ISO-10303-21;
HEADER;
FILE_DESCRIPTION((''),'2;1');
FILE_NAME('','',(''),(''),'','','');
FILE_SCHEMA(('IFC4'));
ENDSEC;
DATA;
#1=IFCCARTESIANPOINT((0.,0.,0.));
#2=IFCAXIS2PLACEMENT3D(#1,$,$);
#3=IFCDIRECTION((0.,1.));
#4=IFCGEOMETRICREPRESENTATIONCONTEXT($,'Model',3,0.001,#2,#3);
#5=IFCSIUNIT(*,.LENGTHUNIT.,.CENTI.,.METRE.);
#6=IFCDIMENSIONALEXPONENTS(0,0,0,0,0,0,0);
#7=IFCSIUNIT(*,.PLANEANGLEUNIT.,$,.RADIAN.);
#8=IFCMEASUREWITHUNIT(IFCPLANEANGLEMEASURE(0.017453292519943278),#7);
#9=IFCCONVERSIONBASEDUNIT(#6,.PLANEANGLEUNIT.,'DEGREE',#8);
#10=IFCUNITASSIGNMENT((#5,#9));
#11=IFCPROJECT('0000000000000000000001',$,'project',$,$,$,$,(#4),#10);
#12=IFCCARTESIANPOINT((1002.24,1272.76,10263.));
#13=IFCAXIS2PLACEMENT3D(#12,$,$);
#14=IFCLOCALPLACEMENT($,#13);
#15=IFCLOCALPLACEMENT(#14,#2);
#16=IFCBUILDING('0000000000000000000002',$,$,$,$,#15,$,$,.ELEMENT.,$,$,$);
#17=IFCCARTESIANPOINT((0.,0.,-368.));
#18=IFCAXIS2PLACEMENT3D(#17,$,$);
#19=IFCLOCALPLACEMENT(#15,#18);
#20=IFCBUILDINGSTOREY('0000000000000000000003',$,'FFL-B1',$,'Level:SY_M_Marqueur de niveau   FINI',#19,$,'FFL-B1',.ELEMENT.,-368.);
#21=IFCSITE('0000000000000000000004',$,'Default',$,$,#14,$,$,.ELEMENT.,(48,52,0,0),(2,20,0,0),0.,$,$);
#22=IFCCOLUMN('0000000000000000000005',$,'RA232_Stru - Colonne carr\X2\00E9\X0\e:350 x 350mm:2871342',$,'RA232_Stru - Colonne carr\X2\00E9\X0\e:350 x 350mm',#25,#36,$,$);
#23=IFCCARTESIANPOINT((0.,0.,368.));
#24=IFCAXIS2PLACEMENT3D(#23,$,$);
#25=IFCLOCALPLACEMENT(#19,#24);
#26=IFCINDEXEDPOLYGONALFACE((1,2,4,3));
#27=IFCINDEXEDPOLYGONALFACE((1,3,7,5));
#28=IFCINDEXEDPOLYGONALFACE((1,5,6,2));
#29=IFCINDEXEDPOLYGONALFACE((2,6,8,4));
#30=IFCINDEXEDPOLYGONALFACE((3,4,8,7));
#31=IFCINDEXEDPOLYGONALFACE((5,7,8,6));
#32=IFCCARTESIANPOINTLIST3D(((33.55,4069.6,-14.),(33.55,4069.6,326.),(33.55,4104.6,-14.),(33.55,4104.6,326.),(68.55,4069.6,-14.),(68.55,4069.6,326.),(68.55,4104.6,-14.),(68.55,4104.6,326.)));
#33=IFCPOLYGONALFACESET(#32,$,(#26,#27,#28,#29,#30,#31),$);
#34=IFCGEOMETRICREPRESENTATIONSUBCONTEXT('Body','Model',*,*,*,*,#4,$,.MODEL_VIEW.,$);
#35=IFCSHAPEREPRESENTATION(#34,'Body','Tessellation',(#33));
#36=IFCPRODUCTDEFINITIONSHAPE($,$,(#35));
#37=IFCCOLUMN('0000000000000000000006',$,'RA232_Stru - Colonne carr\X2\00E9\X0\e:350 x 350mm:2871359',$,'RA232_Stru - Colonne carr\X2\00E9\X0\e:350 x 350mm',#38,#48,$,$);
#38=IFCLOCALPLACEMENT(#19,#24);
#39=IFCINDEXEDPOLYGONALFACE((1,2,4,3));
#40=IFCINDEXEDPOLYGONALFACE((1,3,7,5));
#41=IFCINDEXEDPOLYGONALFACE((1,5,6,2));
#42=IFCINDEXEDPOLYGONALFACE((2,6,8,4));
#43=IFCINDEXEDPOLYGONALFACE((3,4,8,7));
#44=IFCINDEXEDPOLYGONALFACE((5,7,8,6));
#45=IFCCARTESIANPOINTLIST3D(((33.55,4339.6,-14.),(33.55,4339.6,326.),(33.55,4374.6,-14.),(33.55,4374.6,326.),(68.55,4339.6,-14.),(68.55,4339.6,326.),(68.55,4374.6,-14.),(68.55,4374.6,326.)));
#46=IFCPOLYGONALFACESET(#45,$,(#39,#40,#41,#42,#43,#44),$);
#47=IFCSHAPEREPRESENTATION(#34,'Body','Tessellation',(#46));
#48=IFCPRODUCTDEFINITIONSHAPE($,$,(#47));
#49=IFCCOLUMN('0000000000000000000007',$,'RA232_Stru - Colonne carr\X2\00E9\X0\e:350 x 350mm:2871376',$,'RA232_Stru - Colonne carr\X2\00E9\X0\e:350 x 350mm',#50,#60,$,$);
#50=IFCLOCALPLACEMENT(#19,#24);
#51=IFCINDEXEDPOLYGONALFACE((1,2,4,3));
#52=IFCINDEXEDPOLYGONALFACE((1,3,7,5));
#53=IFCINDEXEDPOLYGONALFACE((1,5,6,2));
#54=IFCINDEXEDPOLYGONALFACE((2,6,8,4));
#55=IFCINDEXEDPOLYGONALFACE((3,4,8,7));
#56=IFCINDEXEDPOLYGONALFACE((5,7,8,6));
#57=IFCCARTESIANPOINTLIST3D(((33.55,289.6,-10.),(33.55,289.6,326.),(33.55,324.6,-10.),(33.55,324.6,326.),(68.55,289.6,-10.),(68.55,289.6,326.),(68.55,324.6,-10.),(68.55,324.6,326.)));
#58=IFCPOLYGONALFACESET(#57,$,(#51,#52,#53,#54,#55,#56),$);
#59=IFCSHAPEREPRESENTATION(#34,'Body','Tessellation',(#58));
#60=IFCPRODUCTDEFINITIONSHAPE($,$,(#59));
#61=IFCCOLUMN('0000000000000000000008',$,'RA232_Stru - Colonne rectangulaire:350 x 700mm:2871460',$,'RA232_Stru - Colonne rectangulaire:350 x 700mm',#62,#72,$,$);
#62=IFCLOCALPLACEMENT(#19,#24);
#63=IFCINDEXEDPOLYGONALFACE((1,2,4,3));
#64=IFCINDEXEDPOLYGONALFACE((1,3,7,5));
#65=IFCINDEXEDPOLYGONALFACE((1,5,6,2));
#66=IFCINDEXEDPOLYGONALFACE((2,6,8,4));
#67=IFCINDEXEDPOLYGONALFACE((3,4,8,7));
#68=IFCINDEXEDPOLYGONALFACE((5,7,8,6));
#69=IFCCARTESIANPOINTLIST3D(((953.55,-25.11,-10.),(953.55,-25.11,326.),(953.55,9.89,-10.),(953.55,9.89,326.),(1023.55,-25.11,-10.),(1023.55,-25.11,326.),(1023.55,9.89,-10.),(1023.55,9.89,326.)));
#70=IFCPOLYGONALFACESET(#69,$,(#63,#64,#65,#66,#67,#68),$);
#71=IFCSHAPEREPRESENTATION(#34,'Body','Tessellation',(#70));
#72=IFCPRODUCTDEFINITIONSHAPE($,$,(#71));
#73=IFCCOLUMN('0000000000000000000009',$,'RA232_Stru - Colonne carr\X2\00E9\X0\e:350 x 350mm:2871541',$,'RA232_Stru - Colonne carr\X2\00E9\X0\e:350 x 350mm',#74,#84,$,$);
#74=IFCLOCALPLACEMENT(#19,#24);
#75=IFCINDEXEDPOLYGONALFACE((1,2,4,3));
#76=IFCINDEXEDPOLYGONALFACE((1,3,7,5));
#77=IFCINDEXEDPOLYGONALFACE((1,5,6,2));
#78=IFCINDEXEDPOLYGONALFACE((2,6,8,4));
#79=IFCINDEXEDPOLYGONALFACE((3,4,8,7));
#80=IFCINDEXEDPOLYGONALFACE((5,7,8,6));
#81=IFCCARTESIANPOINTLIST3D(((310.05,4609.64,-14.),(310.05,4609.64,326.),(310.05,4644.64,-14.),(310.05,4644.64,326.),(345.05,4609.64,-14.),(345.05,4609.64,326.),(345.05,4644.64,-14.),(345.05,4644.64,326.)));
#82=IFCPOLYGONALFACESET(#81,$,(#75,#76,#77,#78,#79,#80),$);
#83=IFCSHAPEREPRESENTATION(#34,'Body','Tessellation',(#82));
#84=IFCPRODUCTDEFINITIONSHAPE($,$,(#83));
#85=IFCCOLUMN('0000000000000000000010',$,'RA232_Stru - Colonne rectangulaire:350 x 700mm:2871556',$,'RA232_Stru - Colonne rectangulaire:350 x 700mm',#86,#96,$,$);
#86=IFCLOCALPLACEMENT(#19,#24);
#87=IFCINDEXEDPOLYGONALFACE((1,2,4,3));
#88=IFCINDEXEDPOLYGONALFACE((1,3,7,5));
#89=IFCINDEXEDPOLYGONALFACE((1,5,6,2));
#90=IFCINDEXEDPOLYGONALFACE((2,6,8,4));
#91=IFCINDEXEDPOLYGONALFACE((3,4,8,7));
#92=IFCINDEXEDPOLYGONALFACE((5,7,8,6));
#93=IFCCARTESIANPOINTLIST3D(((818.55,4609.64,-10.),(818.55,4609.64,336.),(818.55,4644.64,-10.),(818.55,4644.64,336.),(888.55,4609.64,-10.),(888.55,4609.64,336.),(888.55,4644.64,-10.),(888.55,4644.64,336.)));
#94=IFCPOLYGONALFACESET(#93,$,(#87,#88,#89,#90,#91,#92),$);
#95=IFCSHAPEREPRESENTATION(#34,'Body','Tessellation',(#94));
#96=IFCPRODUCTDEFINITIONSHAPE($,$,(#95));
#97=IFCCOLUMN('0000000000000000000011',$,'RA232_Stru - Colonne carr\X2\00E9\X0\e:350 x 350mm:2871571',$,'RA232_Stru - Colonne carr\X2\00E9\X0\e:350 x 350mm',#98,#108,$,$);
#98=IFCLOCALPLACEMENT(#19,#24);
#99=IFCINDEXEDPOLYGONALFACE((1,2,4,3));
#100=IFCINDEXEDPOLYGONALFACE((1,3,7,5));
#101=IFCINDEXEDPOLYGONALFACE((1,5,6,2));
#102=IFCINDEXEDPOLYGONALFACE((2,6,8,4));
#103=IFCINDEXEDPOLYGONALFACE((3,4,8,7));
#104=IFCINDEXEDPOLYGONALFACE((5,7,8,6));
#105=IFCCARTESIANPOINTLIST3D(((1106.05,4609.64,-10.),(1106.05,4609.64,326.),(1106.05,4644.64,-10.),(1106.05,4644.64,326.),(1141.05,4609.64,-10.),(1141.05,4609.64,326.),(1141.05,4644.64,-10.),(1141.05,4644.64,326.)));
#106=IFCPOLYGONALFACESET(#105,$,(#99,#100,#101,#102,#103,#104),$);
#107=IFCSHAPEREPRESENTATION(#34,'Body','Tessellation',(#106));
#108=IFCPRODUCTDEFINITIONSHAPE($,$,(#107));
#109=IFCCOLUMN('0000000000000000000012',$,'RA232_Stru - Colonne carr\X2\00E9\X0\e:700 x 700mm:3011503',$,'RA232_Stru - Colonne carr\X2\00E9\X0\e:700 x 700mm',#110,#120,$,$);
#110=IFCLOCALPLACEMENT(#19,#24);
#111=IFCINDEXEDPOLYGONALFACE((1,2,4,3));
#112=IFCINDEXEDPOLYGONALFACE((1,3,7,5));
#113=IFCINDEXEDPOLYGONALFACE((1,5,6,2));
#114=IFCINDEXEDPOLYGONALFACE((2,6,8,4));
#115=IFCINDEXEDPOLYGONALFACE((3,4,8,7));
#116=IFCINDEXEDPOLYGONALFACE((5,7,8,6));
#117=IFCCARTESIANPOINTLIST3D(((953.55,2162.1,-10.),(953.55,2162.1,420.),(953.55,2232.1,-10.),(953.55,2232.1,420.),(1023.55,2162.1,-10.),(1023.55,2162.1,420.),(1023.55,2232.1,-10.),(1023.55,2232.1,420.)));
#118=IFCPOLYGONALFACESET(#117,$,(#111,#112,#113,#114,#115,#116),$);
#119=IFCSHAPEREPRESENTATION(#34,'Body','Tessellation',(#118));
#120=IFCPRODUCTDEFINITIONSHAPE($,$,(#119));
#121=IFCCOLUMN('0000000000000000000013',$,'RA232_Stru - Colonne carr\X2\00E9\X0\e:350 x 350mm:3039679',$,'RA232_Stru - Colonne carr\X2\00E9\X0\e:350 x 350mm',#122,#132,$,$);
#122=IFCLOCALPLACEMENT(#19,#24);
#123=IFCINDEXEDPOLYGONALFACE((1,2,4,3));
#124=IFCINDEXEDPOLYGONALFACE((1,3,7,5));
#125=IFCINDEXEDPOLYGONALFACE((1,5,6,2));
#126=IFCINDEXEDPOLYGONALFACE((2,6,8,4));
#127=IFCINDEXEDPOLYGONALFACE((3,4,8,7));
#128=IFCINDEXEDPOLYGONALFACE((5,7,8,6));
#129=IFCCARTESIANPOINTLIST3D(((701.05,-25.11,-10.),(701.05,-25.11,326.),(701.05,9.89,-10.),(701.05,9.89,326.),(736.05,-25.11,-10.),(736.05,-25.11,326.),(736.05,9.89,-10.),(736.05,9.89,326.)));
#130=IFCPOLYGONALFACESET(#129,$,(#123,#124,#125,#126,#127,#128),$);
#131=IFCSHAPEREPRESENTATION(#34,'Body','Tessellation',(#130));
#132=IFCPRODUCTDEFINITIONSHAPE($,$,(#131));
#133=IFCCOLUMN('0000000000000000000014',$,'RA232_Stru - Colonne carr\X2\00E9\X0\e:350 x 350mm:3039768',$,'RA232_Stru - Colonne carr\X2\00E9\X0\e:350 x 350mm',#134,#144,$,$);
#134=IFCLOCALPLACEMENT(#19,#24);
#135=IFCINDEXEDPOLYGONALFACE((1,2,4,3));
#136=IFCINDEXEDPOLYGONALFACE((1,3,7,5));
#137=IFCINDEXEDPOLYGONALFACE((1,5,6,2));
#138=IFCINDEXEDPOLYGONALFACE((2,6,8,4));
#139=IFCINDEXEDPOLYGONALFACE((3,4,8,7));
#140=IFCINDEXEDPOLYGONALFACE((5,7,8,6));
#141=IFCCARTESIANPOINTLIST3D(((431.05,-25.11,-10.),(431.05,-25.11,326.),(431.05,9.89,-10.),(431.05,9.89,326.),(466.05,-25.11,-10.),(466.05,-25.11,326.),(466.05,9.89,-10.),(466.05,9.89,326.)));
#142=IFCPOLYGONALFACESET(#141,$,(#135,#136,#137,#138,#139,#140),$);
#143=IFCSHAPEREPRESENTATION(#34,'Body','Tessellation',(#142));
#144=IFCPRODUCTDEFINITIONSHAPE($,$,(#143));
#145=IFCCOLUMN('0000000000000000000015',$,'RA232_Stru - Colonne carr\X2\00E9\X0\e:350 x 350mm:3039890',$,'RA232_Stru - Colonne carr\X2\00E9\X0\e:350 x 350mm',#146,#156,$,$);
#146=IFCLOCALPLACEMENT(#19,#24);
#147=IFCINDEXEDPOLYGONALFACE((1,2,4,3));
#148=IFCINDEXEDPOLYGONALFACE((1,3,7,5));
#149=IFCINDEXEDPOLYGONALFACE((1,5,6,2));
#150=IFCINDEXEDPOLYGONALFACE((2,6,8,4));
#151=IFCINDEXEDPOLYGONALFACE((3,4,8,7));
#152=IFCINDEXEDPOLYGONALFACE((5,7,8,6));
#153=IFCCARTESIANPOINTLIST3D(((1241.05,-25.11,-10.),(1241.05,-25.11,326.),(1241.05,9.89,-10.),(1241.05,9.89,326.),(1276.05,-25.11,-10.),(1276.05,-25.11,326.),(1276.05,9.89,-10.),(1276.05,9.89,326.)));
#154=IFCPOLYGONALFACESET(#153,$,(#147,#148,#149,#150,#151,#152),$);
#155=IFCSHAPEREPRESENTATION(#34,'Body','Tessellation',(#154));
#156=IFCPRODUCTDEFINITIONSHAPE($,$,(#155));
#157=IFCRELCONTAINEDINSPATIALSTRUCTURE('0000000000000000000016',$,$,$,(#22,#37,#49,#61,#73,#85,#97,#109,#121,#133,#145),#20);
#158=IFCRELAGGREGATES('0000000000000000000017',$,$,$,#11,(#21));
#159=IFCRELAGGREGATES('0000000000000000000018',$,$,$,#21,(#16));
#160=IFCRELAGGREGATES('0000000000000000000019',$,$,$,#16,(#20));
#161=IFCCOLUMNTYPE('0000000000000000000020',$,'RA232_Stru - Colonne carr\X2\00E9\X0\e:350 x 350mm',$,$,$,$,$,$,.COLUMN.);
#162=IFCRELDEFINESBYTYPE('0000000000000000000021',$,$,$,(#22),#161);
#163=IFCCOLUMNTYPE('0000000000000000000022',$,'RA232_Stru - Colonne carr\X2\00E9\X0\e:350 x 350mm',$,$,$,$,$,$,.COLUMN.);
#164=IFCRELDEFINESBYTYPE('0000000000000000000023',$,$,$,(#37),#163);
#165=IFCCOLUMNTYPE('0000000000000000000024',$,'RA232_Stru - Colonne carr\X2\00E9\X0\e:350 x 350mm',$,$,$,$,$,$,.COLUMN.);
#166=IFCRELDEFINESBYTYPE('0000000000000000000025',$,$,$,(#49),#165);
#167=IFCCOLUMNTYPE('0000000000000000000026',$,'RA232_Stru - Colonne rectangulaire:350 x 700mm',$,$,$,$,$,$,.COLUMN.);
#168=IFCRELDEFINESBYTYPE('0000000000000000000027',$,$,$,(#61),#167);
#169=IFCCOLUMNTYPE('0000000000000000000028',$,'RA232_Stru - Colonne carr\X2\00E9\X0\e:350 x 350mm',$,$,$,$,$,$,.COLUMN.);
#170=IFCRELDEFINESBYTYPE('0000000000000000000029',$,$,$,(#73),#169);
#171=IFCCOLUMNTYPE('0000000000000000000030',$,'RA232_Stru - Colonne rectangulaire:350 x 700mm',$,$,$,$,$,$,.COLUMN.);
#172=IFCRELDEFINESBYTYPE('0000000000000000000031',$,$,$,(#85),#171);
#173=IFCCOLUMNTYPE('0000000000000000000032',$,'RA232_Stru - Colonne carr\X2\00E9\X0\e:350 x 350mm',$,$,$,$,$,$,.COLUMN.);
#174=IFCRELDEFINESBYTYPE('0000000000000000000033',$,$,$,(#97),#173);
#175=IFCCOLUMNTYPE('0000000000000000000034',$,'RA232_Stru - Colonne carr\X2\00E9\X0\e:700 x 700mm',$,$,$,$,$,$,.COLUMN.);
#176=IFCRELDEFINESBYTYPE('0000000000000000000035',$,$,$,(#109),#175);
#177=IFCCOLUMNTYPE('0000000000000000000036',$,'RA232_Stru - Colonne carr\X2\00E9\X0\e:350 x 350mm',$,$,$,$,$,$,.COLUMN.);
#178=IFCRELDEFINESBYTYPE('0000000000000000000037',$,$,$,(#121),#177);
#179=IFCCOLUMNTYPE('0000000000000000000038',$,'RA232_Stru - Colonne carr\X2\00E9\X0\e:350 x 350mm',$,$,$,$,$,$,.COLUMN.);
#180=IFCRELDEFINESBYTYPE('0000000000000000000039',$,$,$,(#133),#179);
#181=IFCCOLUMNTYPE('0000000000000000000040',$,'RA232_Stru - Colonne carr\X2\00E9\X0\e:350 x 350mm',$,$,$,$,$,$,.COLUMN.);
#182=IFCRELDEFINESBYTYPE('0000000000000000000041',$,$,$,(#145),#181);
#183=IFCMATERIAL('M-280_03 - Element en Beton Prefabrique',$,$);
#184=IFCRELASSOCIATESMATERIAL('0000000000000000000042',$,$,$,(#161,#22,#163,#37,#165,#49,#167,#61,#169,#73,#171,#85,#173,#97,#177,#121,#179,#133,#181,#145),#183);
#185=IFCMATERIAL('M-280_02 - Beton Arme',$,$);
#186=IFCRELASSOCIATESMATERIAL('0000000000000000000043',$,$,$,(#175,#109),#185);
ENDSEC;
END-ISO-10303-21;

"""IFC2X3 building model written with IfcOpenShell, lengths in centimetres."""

from ifc_helpers import new_model, entity, si_unit, converted_unit, direction, frame, frame_2d, origin, place, context, subcontext, project, spatial, rectangle, extrude, source, transform, mapped, material, type_object, type_shapes, element, save


model = new_model("IFC2X3")

# Units and contexts
model_context = context("Model", 3, precision=0.001, world=origin(), true_north=direction((0.0, 1.0)))
body_context = subcontext(model_context, "Body", "Model", "MODEL_VIEW")
ifc_project = project(units=[si_unit("LENGTHUNIT", "METRE", prefix="CENTI"), converted_unit("PLANEANGLEUNIT", "DEGREE", entity("IfcPlaneAngleMeasure", 0.017453292519943278), si_unit("PLANEANGLEUNIT", "RADIAN"), dimensions=[0, 0, 0, 0, 0, 0, 0])], contexts=[model_context])

# Site, building, storey
site_placement = place(None, frame((1002.24, 1272.76, 10263.0)))
site = spatial("IfcSite", under=ifc_project, at=site_placement, Name="Default", CompositionType="ELEMENT", RefLatitude=(48, 52, 0, 0), RefLongitude=(2, 20, 0, 0), RefElevation=0.0)
building_placement = place(site_placement, origin())
building = spatial("IfcBuilding", under=site, at=building_placement, CompositionType="ELEMENT")
storey_placement = place(building_placement, frame((0.0, 0.0, -368.0)))
storey = spatial("IfcBuildingStorey", under=building, at=storey_placement, Name="FFL-B1", ObjectType="Level:SY_M_Marqueur de niveau   FINI", LongName="FFL-B1", CompositionType="ELEMENT", Elevation=-368.0)

# Columns
ifc_material_1 = material(Name="M-280_03 - Element en Beton Prefabrique")
column_type_1 = type_object("IfcColumnType", Name="RA232_Stru - Colonne carrée:350 x 350mm", PredefinedType="COLUMN", material=ifc_material_1)
shared_shape_1 = source(origin(), body_context, "Body", "SweptSolid", [
    extrude(rectangle(XDim=35.0, YDim=35.0, at=frame_2d((0.0, 0.0), x_axis=(1.0, 0.0))), frame((51.05, 4087.1, -14.0), z_axis=(0.0, 0.0, 1.0), x_axis=(-1.0, 0.0, 0.0)), (0.0, 0.0, 1.0), 340.0),
])
type_shapes(column_type_1, [shared_shape_1])
column_1_placement = place(storey_placement, frame((0.0, 0.0, 368.0)))
element("IfcColumn", 1, at=column_1_placement, inside=storey, type_object=column_type_1, material=ifc_material_1, Name="RA232_Stru - Colonne carrée:350 x 350mm:2871342", ObjectType="RA232_Stru - Colonne carrée:350 x 350mm", context=body_context, shape_type="MappedRepresentation", body=[
    mapped(shared_shape_1, transform((0.0, 0.0, 0.0), scale=1.0)),
])
column_type_2 = type_object("IfcColumnType", Name="RA232_Stru - Colonne carrée:350 x 350mm", PredefinedType="COLUMN", material=ifc_material_1)
shared_shape_2 = source(origin(), body_context, "Body", "SweptSolid", [
    extrude(rectangle(XDim=35.0, YDim=35.0, at=frame_2d((0.0, 0.0), x_axis=(1.0, 0.0))), frame((51.05, 4357.1, -14.0), z_axis=(0.0, 0.0, 1.0), x_axis=(-1.0, 0.0, 0.0)), (0.0, 0.0, 1.0), 340.0),
])
type_shapes(column_type_2, [shared_shape_2])
column_2_placement = place(storey_placement, frame((0.0, 0.0, 368.0)))
element("IfcColumn", 2, at=column_2_placement, inside=storey, type_object=column_type_2, material=ifc_material_1, Name="RA232_Stru - Colonne carrée:350 x 350mm:2871359", ObjectType="RA232_Stru - Colonne carrée:350 x 350mm", context=body_context, shape_type="MappedRepresentation", body=[
    mapped(shared_shape_2, transform((0.0, 0.0, 0.0), scale=1.0)),
])
column_type_3 = type_object("IfcColumnType", Name="RA232_Stru - Colonne carrée:350 x 350mm", PredefinedType="COLUMN", material=ifc_material_1)
shared_shape_3 = source(origin(), body_context, "Body", "SweptSolid", [
    extrude(rectangle(XDim=35.0, YDim=35.0, at=frame_2d((0.0, 0.0), x_axis=(1.0, 0.0))), frame((51.05, 307.1, -10.0), z_axis=(0.0, 0.0, 1.0), x_axis=(-1.0, 0.0, 0.0)), (0.0, 0.0, 1.0), 336.0),
])
type_shapes(column_type_3, [shared_shape_3])
column_3_placement = place(storey_placement, frame((0.0, 0.0, 368.0)))
element("IfcColumn", 3, at=column_3_placement, inside=storey, type_object=column_type_3, material=ifc_material_1, Name="RA232_Stru - Colonne carrée:350 x 350mm:2871376", ObjectType="RA232_Stru - Colonne carrée:350 x 350mm", context=body_context, shape_type="MappedRepresentation", body=[
    mapped(shared_shape_3, transform((0.0, 0.0, 0.0), scale=1.0)),
])
column_type_4 = type_object("IfcColumnType", Name="RA232_Stru - Colonne rectangulaire:350 x 700mm", PredefinedType="COLUMN", material=ifc_material_1)
shared_shape_4 = source(origin(), body_context, "Body", "SweptSolid", [
    extrude(rectangle(XDim=35.0, YDim=70.0, at=frame_2d((0.0, 0.0), x_axis=(1.0, 0.0))), frame((988.55, -7.61, -10.0), z_axis=(0.0, 0.0, 1.0), x_axis=(0.0, -1.0, 0.0)), (0.0, 0.0, 1.0), 336.0),
])
type_shapes(column_type_4, [shared_shape_4])
column_4_placement = place(storey_placement, frame((0.0, 0.0, 368.0)))
element("IfcColumn", 4, at=column_4_placement, inside=storey, type_object=column_type_4, material=ifc_material_1, Name="RA232_Stru - Colonne rectangulaire:350 x 700mm:2871460", ObjectType="RA232_Stru - Colonne rectangulaire:350 x 700mm", context=body_context, shape_type="MappedRepresentation", body=[
    mapped(shared_shape_4, transform((0.0, 0.0, 0.0), scale=1.0)),
])
column_type_5 = type_object("IfcColumnType", Name="RA232_Stru - Colonne carrée:350 x 350mm", PredefinedType="COLUMN", material=ifc_material_1)
shared_shape_5 = source(origin(), body_context, "Body", "SweptSolid", [
    extrude(rectangle(XDim=35.0, YDim=35.0, at=frame_2d((0.0, 0.0), x_axis=(1.0, 0.0))), frame((327.55, 4627.14, -14.0), z_axis=(0.0, 0.0, 1.0), x_axis=(-1.0, 0.0, 0.0)), (0.0, 0.0, 1.0), 340.0),
])
type_shapes(column_type_5, [shared_shape_5])
column_5_placement = place(storey_placement, frame((0.0, 0.0, 368.0)))
element("IfcColumn", 5, at=column_5_placement, inside=storey, type_object=column_type_5, material=ifc_material_1, Name="RA232_Stru - Colonne carrée:350 x 350mm:2871541", ObjectType="RA232_Stru - Colonne carrée:350 x 350mm", context=body_context, shape_type="MappedRepresentation", body=[
    mapped(shared_shape_5, transform((0.0, 0.0, 0.0), scale=1.0)),
])
column_type_6 = type_object("IfcColumnType", Name="RA232_Stru - Colonne rectangulaire:350 x 700mm", PredefinedType="COLUMN", material=ifc_material_1)
shared_shape_6 = source(origin(), body_context, "Body", "SweptSolid", [
    extrude(rectangle(XDim=35.0, YDim=70.0, at=frame_2d((0.0, 0.0), x_axis=(1.0, 0.0))), frame((853.55, 4627.14, -10.0), z_axis=(0.0, 0.0, 1.0), x_axis=(0.0, -1.0, 0.0)), (0.0, 0.0, 1.0), 346.0),
])
type_shapes(column_type_6, [shared_shape_6])
column_6_placement = place(storey_placement, frame((0.0, 0.0, 368.0)))
element("IfcColumn", 6, at=column_6_placement, inside=storey, type_object=column_type_6, material=ifc_material_1, Name="RA232_Stru - Colonne rectangulaire:350 x 700mm:2871556", ObjectType="RA232_Stru - Colonne rectangulaire:350 x 700mm", context=body_context, shape_type="MappedRepresentation", body=[
    mapped(shared_shape_6, transform((0.0, 0.0, 0.0), scale=1.0)),
])
column_type_7 = type_object("IfcColumnType", Name="RA232_Stru - Colonne carrée:350 x 350mm", PredefinedType="COLUMN", material=ifc_material_1)
shared_shape_7 = source(origin(), body_context, "Body", "SweptSolid", [
    extrude(rectangle(XDim=35.0, YDim=35.0, at=frame_2d((0.0, 0.0), x_axis=(1.0, 0.0))), frame((1123.55, 4627.14, -10.0), z_axis=(0.0, 0.0, 1.0), x_axis=(-1.0, 0.0, 0.0)), (0.0, 0.0, 1.0), 336.0),
])
type_shapes(column_type_7, [shared_shape_7])
column_7_placement = place(storey_placement, frame((0.0, 0.0, 368.0)))
element("IfcColumn", 7, at=column_7_placement, inside=storey, type_object=column_type_7, material=ifc_material_1, Name="RA232_Stru - Colonne carrée:350 x 350mm:2871571", ObjectType="RA232_Stru - Colonne carrée:350 x 350mm", context=body_context, shape_type="MappedRepresentation", body=[
    mapped(shared_shape_7, transform((0.0, 0.0, 0.0), scale=1.0)),
])
ifc_material_2 = material(Name="M-280_02 - Beton Arme")
column_type_8 = type_object("IfcColumnType", Name="RA232_Stru - Colonne carrée:700 x 700mm", PredefinedType="COLUMN", material=ifc_material_2)
shared_shape_8 = source(origin(), body_context, "Body", "SweptSolid", [
    extrude(rectangle(XDim=70.0, YDim=70.0, at=frame_2d((0.0, 0.0), x_axis=(1.0, 0.0))), frame((988.55, 2197.1, -10.0), z_axis=(0.0, 0.0, 1.0), x_axis=(-1.0, 0.0, 0.0)), (0.0, 0.0, 1.0), 430.0),
])
type_shapes(column_type_8, [shared_shape_8])
column_8_placement = place(storey_placement, frame((0.0, 0.0, 368.0)))
element("IfcColumn", 8, at=column_8_placement, inside=storey, type_object=column_type_8, material=ifc_material_2, Name="RA232_Stru - Colonne carrée:700 x 700mm:3011503", ObjectType="RA232_Stru - Colonne carrée:700 x 700mm", context=body_context, shape_type="MappedRepresentation", body=[
    mapped(shared_shape_8, transform((0.0, 0.0, 0.0), scale=1.0)),
])
column_type_9 = type_object("IfcColumnType", Name="RA232_Stru - Colonne carrée:350 x 350mm", PredefinedType="COLUMN", material=ifc_material_1)
shared_shape_9 = source(origin(), body_context, "Body", "SweptSolid", [
    extrude(rectangle(XDim=35.0, YDim=35.0, at=frame_2d((0.0, 0.0), x_axis=(1.0, 0.0))), frame((718.55, -7.61, -10.0), z_axis=(0.0, 0.0, 1.0), x_axis=(-1.0, 0.0, 0.0)), (0.0, 0.0, 1.0), 336.0),
])
type_shapes(column_type_9, [shared_shape_9])
column_9_placement = place(storey_placement, frame((0.0, 0.0, 368.0)))
element("IfcColumn", 9, at=column_9_placement, inside=storey, type_object=column_type_9, material=ifc_material_1, Name="RA232_Stru - Colonne carrée:350 x 350mm:3039679", ObjectType="RA232_Stru - Colonne carrée:350 x 350mm", context=body_context, shape_type="MappedRepresentation", body=[
    mapped(shared_shape_9, transform((0.0, 0.0, 0.0), scale=1.0)),
])
column_type_10 = type_object("IfcColumnType", Name="RA232_Stru - Colonne carrée:350 x 350mm", PredefinedType="COLUMN", material=ifc_material_1)
shared_shape_10 = source(origin(), body_context, "Body", "SweptSolid", [
    extrude(rectangle(XDim=35.0, YDim=35.0, at=frame_2d((0.0, 0.0), x_axis=(1.0, 0.0))), frame((448.55, -7.61, -10.0), z_axis=(0.0, 0.0, 1.0), x_axis=(-1.0, 0.0, 0.0)), (0.0, 0.0, 1.0), 336.0),
])
type_shapes(column_type_10, [shared_shape_10])
column_10_placement = place(storey_placement, frame((0.0, 0.0, 368.0)))
element("IfcColumn", 10, at=column_10_placement, inside=storey, type_object=column_type_10, material=ifc_material_1, Name="RA232_Stru - Colonne carrée:350 x 350mm:3039768", ObjectType="RA232_Stru - Colonne carrée:350 x 350mm", context=body_context, shape_type="MappedRepresentation", body=[
    mapped(shared_shape_10, transform((0.0, 0.0, 0.0), scale=1.0)),
])
column_type_11 = type_object("IfcColumnType", Name="RA232_Stru - Colonne carrée:350 x 350mm", PredefinedType="COLUMN", material=ifc_material_1)
shared_shape_11 = source(origin(), body_context, "Body", "SweptSolid", [
    extrude(rectangle(XDim=35.0, YDim=35.0, at=frame_2d((0.0, 0.0), x_axis=(1.0, 0.0))), frame((1258.55, -7.61, -10.0), z_axis=(0.0, 0.0, 1.0), x_axis=(-1.0, 0.0, 0.0)), (0.0, 0.0, 1.0), 336.0),
])
type_shapes(column_type_11, [shared_shape_11])
column_11_placement = place(storey_placement, frame((0.0, 0.0, 368.0)))
element("IfcColumn", 11, at=column_11_placement, inside=storey, type_object=column_type_11, material=ifc_material_1, Name="RA232_Stru - Colonne carrée:350 x 350mm:3039890", ObjectType="RA232_Stru - Colonne carrée:350 x 350mm", context=body_context, shape_type="MappedRepresentation", body=[
    mapped(shared_shape_11, transform((0.0, 0.0, 0.0), scale=1.0)),
])

save(model, "model.ifc")
